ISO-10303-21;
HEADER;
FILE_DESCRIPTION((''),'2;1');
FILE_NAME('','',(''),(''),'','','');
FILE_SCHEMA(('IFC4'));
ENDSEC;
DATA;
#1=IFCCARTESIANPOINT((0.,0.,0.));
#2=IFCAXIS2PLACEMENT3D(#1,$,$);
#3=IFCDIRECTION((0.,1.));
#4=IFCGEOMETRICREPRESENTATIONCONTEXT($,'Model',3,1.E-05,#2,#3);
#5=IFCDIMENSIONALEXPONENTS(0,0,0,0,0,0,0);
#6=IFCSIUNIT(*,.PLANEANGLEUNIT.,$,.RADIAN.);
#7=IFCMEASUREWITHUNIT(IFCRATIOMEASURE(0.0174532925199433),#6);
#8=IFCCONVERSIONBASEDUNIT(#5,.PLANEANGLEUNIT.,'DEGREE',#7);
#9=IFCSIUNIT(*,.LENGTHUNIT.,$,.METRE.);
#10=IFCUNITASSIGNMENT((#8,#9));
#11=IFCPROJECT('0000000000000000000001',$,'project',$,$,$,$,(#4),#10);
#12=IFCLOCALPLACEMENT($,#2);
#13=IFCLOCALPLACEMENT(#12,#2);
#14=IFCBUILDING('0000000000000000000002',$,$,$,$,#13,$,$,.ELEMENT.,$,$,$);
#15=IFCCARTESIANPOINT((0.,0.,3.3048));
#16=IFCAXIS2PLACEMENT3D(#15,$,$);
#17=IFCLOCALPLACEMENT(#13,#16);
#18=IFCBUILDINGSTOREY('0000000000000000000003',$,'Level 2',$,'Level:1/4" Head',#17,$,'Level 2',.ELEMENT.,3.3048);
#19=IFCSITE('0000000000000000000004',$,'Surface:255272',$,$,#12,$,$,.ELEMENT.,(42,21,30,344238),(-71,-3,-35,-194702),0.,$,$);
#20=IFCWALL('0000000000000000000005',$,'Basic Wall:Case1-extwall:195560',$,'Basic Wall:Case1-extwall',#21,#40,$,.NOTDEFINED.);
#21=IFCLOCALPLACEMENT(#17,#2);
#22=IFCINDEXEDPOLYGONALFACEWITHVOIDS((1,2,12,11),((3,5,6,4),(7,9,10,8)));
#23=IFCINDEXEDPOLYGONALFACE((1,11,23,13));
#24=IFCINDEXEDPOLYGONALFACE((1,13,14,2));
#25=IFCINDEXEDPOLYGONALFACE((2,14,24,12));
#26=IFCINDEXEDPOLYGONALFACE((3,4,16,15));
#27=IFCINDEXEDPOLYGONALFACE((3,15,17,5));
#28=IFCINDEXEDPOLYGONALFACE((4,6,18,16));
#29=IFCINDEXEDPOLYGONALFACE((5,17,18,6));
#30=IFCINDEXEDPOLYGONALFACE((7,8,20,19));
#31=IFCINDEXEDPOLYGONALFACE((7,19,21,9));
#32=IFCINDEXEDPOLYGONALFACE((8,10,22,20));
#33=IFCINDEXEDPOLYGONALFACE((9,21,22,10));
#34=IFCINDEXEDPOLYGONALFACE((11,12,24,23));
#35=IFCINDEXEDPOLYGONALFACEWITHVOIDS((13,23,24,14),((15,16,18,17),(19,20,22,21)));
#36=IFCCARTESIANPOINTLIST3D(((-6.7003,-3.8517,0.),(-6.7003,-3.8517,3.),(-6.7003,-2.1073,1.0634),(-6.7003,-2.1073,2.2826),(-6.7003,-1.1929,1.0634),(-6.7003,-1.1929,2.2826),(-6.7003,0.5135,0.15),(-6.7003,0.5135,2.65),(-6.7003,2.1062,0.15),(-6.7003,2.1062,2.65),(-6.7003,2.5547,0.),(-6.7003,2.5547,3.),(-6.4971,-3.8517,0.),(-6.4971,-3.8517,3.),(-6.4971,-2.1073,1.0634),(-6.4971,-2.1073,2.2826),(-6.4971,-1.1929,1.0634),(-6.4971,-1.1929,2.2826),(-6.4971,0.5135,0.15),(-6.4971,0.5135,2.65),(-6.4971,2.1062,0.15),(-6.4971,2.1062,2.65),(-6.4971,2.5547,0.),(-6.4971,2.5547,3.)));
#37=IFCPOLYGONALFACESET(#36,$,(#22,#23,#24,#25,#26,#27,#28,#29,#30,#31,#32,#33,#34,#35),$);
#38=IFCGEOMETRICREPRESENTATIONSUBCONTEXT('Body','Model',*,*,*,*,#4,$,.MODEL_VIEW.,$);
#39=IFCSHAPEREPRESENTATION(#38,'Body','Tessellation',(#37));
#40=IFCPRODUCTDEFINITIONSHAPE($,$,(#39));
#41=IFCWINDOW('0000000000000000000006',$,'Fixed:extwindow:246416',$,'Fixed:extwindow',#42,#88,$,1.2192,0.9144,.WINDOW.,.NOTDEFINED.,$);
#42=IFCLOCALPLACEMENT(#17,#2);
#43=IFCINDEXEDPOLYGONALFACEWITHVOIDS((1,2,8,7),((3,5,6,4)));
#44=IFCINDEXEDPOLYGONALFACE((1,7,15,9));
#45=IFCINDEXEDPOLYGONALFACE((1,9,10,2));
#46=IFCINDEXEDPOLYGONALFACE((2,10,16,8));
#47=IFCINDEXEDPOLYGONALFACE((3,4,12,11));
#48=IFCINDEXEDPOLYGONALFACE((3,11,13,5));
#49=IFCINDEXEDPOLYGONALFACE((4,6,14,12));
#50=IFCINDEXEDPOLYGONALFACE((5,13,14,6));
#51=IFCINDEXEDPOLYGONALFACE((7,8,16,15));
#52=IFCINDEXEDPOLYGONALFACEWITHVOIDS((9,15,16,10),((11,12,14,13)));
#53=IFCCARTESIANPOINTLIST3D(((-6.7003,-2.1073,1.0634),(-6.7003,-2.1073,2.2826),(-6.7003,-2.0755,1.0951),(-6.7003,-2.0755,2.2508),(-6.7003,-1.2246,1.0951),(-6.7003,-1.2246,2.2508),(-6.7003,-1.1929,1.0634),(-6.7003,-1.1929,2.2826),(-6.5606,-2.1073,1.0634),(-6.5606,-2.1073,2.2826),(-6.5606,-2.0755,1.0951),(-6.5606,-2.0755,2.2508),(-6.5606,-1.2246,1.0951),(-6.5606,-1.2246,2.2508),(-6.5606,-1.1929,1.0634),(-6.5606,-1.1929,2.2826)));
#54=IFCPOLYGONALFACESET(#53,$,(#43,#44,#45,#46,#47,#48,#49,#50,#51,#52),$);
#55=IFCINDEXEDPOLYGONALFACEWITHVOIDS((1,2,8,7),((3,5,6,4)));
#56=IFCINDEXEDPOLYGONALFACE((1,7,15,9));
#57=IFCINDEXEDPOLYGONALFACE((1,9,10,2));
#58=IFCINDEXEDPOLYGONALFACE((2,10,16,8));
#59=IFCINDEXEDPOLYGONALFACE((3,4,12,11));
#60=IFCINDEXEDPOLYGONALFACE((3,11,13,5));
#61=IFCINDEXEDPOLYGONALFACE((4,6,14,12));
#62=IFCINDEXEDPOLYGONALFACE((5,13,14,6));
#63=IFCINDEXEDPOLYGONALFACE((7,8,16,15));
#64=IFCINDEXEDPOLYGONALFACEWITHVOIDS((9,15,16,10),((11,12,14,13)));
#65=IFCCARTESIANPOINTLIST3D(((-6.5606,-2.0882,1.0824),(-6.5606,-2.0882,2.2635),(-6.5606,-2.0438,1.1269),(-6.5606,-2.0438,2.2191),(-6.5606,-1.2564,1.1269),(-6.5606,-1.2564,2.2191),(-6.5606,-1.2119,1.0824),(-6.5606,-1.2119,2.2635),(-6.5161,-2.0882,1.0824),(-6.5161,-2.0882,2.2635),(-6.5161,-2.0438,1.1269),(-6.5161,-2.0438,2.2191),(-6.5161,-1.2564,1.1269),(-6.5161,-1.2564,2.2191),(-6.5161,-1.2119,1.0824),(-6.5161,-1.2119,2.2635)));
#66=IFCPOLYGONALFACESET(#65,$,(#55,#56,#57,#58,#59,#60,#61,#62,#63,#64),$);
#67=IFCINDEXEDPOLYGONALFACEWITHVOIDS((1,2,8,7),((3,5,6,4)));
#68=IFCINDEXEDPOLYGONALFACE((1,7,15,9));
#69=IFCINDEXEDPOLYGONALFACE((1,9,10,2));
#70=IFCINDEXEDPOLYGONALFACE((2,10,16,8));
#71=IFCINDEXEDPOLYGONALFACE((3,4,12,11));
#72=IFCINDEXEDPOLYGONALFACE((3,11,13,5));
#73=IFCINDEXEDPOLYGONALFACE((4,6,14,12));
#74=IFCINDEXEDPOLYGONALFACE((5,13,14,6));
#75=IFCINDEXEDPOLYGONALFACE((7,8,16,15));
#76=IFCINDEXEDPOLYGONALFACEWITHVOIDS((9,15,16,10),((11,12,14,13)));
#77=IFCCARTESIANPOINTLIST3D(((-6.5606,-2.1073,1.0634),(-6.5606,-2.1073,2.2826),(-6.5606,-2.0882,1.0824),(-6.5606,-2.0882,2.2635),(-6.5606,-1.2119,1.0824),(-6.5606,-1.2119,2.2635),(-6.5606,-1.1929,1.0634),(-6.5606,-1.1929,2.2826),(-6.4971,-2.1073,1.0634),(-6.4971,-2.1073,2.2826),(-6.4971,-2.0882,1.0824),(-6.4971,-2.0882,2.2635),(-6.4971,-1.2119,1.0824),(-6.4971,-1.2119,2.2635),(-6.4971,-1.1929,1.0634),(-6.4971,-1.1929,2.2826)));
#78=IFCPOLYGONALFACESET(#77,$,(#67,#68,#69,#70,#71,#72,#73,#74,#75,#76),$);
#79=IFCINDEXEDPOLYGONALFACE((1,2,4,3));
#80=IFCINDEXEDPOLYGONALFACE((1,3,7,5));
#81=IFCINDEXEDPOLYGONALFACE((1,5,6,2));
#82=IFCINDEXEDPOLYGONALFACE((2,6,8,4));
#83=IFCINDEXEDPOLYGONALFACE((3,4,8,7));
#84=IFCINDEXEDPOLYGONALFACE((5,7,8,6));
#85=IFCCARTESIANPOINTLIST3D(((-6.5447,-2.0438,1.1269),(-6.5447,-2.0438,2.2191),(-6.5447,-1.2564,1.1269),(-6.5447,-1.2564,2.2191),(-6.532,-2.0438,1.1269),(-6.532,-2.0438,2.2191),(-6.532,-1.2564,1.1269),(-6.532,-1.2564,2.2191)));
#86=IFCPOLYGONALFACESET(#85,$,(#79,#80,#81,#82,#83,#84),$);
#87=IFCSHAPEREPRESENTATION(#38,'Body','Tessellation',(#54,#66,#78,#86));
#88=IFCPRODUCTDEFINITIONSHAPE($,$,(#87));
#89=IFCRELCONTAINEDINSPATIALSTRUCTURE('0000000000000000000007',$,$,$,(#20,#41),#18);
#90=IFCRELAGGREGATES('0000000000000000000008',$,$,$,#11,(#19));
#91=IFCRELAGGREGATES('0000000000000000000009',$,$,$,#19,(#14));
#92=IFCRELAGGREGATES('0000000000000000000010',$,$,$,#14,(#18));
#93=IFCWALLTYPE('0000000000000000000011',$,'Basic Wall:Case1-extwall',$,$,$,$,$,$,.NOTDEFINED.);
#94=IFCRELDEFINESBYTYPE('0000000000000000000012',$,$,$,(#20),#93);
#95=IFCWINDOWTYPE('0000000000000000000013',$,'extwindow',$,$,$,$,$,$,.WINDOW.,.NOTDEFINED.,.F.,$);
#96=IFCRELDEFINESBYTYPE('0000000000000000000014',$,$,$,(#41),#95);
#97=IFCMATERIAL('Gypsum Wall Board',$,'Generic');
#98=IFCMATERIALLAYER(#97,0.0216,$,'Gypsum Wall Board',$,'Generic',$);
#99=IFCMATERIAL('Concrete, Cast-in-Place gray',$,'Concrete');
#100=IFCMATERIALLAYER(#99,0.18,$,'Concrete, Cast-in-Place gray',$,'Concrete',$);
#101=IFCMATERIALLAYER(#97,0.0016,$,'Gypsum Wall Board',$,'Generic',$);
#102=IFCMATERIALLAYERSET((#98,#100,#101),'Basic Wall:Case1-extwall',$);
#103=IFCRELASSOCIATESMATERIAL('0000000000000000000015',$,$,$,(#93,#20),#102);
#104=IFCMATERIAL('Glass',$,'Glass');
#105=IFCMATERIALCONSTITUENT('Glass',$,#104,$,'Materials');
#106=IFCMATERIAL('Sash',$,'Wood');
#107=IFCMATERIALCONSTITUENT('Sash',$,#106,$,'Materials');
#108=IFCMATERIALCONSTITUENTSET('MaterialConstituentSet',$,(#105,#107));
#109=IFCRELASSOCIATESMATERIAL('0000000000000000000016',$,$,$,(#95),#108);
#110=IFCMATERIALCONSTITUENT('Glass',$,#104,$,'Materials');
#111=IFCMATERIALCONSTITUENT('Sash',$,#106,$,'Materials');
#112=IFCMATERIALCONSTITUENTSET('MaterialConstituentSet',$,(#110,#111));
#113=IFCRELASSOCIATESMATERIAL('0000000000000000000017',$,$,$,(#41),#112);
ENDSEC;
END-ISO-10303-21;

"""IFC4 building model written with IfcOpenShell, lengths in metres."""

from ifc_helpers import new_model, entity, si_unit, converted_unit, direction, frame, frame_2d, origin, place, context, subcontext, project, spatial, polyline, rectangle, outline, extrude, clip, bounded_halfspace, source, transform, mapped, material, layer, layer_set, layer_usage, constituent, constituent_set, type_object, type_shapes, element, fill, save


model = new_model("IFC4")

# Units and contexts
model_context = context("Model", 3, precision=1e-05, world=origin(), true_north=direction((0.0, 1.0)))
body_context = subcontext(model_context, "Body", "Model", "MODEL_VIEW")
ifc_project = project(units=[converted_unit("PLANEANGLEUNIT", "DEGREE", entity("IfcRatioMeasure", 0.0174532925199433), si_unit("PLANEANGLEUNIT", "RADIAN"), dimensions=[0, 0, 0, 0, 0, 0, 0]), si_unit("LENGTHUNIT", "METRE")], contexts=[model_context])

# Site, building, storey
site_placement = place(None, origin())
site = spatial("IfcSite", under=ifc_project, at=site_placement, Name="Surface:255272", CompositionType="ELEMENT", RefLatitude=(42, 21, 30, 344238), RefLongitude=(-71, -3, -35, -194702), RefElevation=0.0)
building_placement = place(site_placement, origin())
building = spatial("IfcBuilding", under=site, at=building_placement, CompositionType="ELEMENT")
storey_placement = place(building_placement, frame((0.0, 0.0, 3.3048)))
storey = spatial("IfcBuildingStorey", under=building, at=storey_placement, Name="Level 2", ObjectType="Level:1/4\" Head", LongName="Level 2", CompositionType="ELEMENT", Elevation=3.3048)

# Wall, openings, window
ifc_material_1 = material(Name="Gypsum Wall Board", Category="Generic")
ifc_layer_1 = layer(ifc_material_1, 0.0216, Name="Gypsum Wall Board", Category="Generic")
ifc_material_2 = material(Name="Concrete, Cast-in-Place gray", Category="Concrete")
ifc_layer_2 = layer(ifc_material_2, 0.18, Name="Concrete, Cast-in-Place gray", Category="Concrete")
ifc_layer_3 = layer(ifc_material_1, 0.0016, Name="Gypsum Wall Board", Category="Generic")
ifc_layer_set_1 = layer_set([ifc_layer_1, ifc_layer_2, ifc_layer_3], Name="Basic Wall:Case1-extwall")
ifc_layer_usage_1 = layer_usage(ifc_layer_set_1, "AXIS2", "NEGATIVE", 0.1016)
wall_type = type_object("IfcWallType", Name="Basic Wall:Case1-extwall", PredefinedType="NOTDEFINED", material=ifc_layer_set_1)
wall_placement = place(storey_placement, frame((-6.5987, -3.8517, 0.0), z_axis=(0.0, 0.0, 1.0), x_axis=(0.000007, 1.0, 0.0)))
wall = element("IfcWall", 1, at=wall_placement, inside=storey, type_object=wall_type, material=ifc_layer_usage_1, Name="Basic Wall:Case1-extwall:195560", ObjectType="Basic Wall:Case1-extwall", PredefinedType="NOTDEFINED", context=body_context, shape_type="Clipping", body=[
    clip(extrude(rectangle(XDim=6.4064, YDim=0.2032, at=frame_2d((3.2032, 0.0), x_axis=(-1.0, 0.0))), origin(), (0.0, 0.0, 1.0), 3.0), bounded_halfspace(frame((0.0, -0.1016, 3.0), z_axis=(0.0, 0.0, 1.0), x_axis=(0.0, -1.0, 0.0)), False, frame((0.0, -0.1016, 3.0)), polyline([(0.0, 0.0), (0.2032, 0.0), (6.2032, 0.0), (6.4064, 0.0), (6.4064, 0.2032), (0.0, 0.2032), (0.0, 0.0)]))),
])
opening_1_placement = place(wall_placement, frame((4.3652, 0.1016, 0.15)))
element("IfcOpeningElement", 2, at=opening_1_placement, cuts=wall, ObjectType="Opening", PredefinedType="OPENING", context=body_context, shape_type="SweptSolid", body=[
    extrude(rectangle(XDim=2.5, YDim=1.5927, at=frame_2d((0.0, 0.0), x_axis=(1.0, 0.0))), frame((0.7963, -0.2032, 1.25), z_axis=(0.0, 1.0, 0.0), x_axis=(0.0, 0.0, -1.0)), (0.0, 0.0, 1.0), 0.2032),
])
opening_2_placement = place(wall_placement, frame((2.6588, 0.1016, 1.0634)))
opening_2 = element("IfcOpeningElement", 3, at=opening_2_placement, cuts=wall, ObjectType="Opening", PredefinedType="OPENING", context=body_context, shape_type="SweptSolid", body=[
    extrude(rectangle(XDim=1.2192, YDim=0.9144, at=frame_2d((0.6096, 0.4572), x_axis=(-1.0, 0.0))), frame((0.0, 0.0, 0.0), z_axis=(-0.000007, -1.0, 0.0), x_axis=(0.0, 0.0, 1.0)), (0.0, 0.0, 1.0), 0.2032),
])
ifc_material_3 = material(Name="Glass", Category="Glass")
ifc_constituent_1 = constituent(ifc_material_3, Name="Glass", Category="Materials")
ifc_material_4 = material(Name="Sash", Category="Wood")
ifc_constituent_2 = constituent(ifc_material_4, Name="Sash", Category="Materials")
ifc_constituent_set_1 = constituent_set(constituents=[ifc_constituent_1, ifc_constituent_2], Name="MaterialConstituentSet")
ifc_constituent_3 = constituent(ifc_material_3, Name="Glass", Category="Materials")
ifc_constituent_4 = constituent(ifc_material_4, Name="Sash", Category="Materials")
ifc_constituent_set_2 = constituent_set(constituents=[ifc_constituent_3, ifc_constituent_4], Name="MaterialConstituentSet")
window_type = type_object("IfcWindowType", Name="extwindow", ParameterTakesPrecedence=False, PartitioningType="NOTDEFINED", PredefinedType="WINDOW", material=ifc_constituent_set_2)
shared_shape_1 = source(origin(), body_context, "Body", "SweptSolid", [
    extrude(outline(polyline([(-0.4572, -0.6096), (0.4572, -0.6096), (0.4572, 0.6096), (-0.4572, 0.6096), (-0.4572, -0.6096)]), holes=[polyline([(-0.4255, -0.5778), (-0.4255, 0.5779), (0.4254, 0.5779), (0.4254, -0.5778), (-0.4255, -0.5778)])]), frame((0.4572, 0.0, 0.6096), z_axis=(0.0, 1.0, 0.0), x_axis=(1.0, 0.0, 0.0)), (0.0, 0.0, 1.0), 0.1397),
    extrude(outline(polyline([(-0.4381, -0.5906), (0.4381, -0.5906), (0.4381, 0.5906), (-0.4381, 0.5906), (-0.4381, -0.5906)]), holes=[polyline([(-0.3937, -0.5461), (-0.3937, 0.5461), (0.3937, 0.5461), (0.3937, -0.5461), (-0.3937, -0.5461)])]), frame((0.4572, 0.1397, 0.6096), z_axis=(0.0, 1.0, 0.0), x_axis=(1.0, 0.0, 0.0)), (0.0, 0.0, 1.0), 0.0445),
    extrude(outline(polyline([(-0.6096, -0.4572), (0.6096, -0.4572), (0.6096, 0.4572), (-0.6096, 0.4572), (-0.6096, -0.4572)]), holes=[polyline([(-0.5905, -0.4381), (-0.5905, 0.4381), (0.5906, 0.4381), (0.5906, -0.4381), (-0.5905, -0.4381)])]), frame((0.4572, 0.1397, 0.6096), z_axis=(0.0, 1.0, 0.0), x_axis=(0.0, 0.0, -1.0)), (0.0, 0.0, 1.0), 0.0635),
    extrude(rectangle(XDim=0.0127, YDim=0.7874, at=frame_2d((0.0, 0.0), x_axis=(1.0, 0.0))), frame((0.4572, 0.1619, 0.0635), z_axis=(0.0, 0.0, 1.0), x_axis=(0.0, 1.0, 0.0)), (0.0, 0.0, 1.0), 1.0922),
])
type_shapes(window_type, [shared_shape_1])
window_placement = place(opening_2_placement, frame((0.0, 0.0, 0.0), z_axis=(0.0, 0.0, 1.0), x_axis=(-1.0, 0.0, 0.0)))
window = element("IfcWindow", 4, at=window_placement, inside=storey, type_object=window_type, material=ifc_constituent_set_1, Name="Fixed:extwindow:246416", ObjectType="Fixed:extwindow", OverallHeight=1.2192, OverallWidth=0.9144, PartitioningType="NOTDEFINED", PredefinedType="WINDOW", context=body_context, shape_type="MappedRepresentation", body=[
    mapped(shared_shape_1, transform((0.0, 0.0, 0.0), scale=1.0)),
])
fill(opening_2, window)

save(model, "model.ifc")
